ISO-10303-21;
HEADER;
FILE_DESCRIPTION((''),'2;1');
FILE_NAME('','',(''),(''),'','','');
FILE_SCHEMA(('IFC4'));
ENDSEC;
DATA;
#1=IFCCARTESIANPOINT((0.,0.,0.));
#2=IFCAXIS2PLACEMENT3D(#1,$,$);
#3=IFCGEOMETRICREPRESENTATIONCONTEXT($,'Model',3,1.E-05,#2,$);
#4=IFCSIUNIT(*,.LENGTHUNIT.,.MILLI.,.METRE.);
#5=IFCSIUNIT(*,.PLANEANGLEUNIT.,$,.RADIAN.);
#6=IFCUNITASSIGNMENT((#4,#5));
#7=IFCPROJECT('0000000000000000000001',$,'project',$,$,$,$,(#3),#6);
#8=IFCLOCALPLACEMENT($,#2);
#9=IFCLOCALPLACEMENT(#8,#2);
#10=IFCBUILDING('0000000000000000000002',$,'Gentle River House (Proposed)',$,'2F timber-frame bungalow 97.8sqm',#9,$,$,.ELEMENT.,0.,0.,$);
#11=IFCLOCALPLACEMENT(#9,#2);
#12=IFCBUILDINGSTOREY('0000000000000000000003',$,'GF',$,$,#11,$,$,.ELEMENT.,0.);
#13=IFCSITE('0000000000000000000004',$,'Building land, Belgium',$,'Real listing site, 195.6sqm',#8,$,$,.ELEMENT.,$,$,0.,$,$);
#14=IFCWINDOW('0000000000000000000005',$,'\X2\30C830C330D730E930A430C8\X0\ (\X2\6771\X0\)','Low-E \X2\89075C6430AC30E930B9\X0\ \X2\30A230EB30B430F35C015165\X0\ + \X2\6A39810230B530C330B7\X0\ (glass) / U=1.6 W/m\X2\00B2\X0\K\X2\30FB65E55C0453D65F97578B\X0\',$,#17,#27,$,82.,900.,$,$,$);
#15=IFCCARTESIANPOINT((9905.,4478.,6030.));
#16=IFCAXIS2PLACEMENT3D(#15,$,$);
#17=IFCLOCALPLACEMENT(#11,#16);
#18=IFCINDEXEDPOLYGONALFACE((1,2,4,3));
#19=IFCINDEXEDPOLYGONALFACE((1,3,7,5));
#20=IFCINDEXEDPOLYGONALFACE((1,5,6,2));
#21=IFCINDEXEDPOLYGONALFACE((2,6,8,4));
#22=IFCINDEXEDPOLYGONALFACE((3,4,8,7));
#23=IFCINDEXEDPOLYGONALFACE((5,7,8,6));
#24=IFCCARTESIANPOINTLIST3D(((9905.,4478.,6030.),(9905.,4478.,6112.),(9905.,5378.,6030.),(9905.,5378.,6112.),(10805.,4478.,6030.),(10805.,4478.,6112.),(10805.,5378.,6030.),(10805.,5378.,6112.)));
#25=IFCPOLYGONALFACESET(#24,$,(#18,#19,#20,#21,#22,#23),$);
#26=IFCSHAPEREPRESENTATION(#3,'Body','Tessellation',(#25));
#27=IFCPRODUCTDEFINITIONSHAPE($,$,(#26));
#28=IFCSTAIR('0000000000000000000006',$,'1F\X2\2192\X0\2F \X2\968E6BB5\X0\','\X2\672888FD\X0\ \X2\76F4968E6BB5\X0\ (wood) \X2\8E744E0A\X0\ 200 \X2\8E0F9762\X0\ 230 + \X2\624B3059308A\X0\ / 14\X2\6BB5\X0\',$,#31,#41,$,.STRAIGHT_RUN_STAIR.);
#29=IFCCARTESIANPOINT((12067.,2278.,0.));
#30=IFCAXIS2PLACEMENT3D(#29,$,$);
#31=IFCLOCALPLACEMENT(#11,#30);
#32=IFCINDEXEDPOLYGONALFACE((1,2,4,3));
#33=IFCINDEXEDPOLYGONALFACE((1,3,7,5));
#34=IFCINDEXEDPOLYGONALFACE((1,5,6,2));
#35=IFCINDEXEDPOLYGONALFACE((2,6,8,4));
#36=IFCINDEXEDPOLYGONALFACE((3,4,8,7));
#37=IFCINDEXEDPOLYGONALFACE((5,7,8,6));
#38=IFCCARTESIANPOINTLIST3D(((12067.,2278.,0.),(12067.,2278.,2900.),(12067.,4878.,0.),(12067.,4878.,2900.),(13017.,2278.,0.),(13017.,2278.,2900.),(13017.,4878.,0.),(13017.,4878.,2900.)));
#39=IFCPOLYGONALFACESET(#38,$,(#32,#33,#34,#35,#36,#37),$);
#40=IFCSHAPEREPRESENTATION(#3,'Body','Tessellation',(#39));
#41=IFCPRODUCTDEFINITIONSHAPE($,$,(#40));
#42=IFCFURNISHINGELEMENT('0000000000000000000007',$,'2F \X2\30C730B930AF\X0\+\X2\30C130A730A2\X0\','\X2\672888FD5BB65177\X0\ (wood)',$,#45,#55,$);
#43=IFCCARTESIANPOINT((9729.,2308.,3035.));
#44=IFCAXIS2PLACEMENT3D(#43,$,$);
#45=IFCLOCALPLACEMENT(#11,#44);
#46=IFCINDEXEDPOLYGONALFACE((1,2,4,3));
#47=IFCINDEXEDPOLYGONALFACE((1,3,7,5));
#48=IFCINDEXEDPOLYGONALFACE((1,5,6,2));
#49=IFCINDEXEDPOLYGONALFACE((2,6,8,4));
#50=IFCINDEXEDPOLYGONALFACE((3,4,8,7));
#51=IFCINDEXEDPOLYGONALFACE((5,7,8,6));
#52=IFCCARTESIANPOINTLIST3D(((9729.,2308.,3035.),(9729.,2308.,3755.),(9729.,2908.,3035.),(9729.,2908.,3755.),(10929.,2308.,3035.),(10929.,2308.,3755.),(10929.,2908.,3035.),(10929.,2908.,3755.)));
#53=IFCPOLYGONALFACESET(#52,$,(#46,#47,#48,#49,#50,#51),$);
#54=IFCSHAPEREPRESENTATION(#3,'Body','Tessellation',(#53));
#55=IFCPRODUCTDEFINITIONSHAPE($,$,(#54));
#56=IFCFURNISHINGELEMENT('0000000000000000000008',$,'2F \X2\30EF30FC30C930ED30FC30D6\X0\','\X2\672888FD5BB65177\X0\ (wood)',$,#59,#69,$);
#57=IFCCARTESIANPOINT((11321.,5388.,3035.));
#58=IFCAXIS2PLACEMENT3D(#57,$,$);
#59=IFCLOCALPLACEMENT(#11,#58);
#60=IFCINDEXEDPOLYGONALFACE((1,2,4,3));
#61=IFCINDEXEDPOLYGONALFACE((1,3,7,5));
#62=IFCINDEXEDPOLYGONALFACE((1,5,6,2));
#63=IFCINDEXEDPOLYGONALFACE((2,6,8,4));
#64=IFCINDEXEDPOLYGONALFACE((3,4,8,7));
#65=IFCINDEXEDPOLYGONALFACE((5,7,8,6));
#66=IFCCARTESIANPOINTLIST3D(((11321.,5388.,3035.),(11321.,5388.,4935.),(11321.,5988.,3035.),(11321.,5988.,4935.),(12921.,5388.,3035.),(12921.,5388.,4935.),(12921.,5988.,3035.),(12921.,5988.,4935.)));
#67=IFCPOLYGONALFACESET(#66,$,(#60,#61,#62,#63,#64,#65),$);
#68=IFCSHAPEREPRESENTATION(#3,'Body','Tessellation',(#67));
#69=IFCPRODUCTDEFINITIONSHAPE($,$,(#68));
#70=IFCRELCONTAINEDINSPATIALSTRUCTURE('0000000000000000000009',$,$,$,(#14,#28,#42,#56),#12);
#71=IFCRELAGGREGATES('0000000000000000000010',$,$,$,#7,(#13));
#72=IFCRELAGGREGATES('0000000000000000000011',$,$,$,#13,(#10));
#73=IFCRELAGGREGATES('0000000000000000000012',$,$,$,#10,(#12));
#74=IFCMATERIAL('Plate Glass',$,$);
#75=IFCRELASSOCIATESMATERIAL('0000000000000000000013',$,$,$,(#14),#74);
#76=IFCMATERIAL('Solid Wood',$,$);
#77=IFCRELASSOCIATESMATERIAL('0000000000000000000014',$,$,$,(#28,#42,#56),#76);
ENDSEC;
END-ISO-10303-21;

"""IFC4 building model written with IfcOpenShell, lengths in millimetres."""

from ifc_helpers import new_model, si_unit, frame, frame_2d, origin, place, context, project, spatial, rectangle, extrude, material, element, save


model = new_model("IFC4")

# Units and contexts
model_context = context("Model", 3, precision=1e-05, world=origin())
ifc_project = project(units=[si_unit("LENGTHUNIT", "METRE", prefix="MILLI"), si_unit("PLANEANGLEUNIT", "RADIAN")], contexts=[model_context])

# Site, building, storey
site_placement = place(None, origin())
site = spatial("IfcSite", under=ifc_project, at=site_placement, Name="Building land, Belgium", ObjectType="Real listing site, 195.6sqm", CompositionType="ELEMENT", RefElevation=0.0)
building_placement = place(site_placement, origin())
building = spatial("IfcBuilding", under=site, at=building_placement, Name="Gentle River House (Proposed)", ObjectType="2F timber-frame bungalow 97.8sqm", CompositionType="ELEMENT", ElevationOfRefHeight=0.0, ElevationOfTerrain=0.0)
storey_placement = place(building_placement, origin())
storey = spatial("IfcBuildingStorey", under=building, at=storey_placement, Name="GF", CompositionType="ELEMENT", Elevation=0.0)

# Shared definitions
ifc_material_1 = material(Name="Solid Wood")

# Shared definitions
ifc_material_2 = material(Name="Plate Glass")

# Window
window_1_placement = place(storey_placement, frame((9905.0, 4478.0, 6030.0)))
element("IfcWindow", 1, at=window_1_placement, inside=storey, material=ifc_material_2, Name="トップライト (東)", Description="Low-E 複層ガラス アルゴン封入 + 樹脂サッシ (glass) / U=1.6 W/m²K・日射取得型", OverallHeight=82.0, OverallWidth=900.0, context=model_context, shape_type="SweptSolid", body=[
    extrude(rectangle(XDim=900.0, YDim=900.0, at=frame_2d((450.0, 450.0))), frame((9905.0, 4478.0, 6030.0)), (0.0, 0.0, 1.0), 82.0),
])

# Stair
stair_placement = place(storey_placement, frame((12067.0, 2278.0, 0.0)))
element("IfcStair", 2, at=stair_placement, inside=storey, material=ifc_material_1, Name="1F→2F 階段", Description="木製 直階段 (wood) 蹴上 200 踏面 230 + 手すり / 14段", PredefinedType="STRAIGHT_RUN_STAIR", context=model_context, shape_type="SweptSolid", body=[
    extrude(rectangle(XDim=950.0, YDim=2600.0, at=frame_2d((475.0, 1300.0))), frame((12067.0, 2278.0, 0.0)), (0.0, 0.0, 1.0), 2900.0),
])

# Furnishing elements
furnishing_1_placement = place(storey_placement, frame((9729.0, 2308.0, 3035.0)))
element("IfcFurnishingElement", 3, at=furnishing_1_placement, inside=storey, material=ifc_material_1, Name="2F デスク+チェア", Description="木製家具 (wood)", context=model_context, shape_type="SweptSolid", body=[
    extrude(rectangle(XDim=1200.0, YDim=600.0, at=frame_2d((600.0, 300.0))), frame((9729.0, 2308.0, 3035.0)), (0.0, 0.0, 1.0), 720.0),
])
furnishing_2_placement = place(storey_placement, frame((11321.0, 5388.0, 3035.0)))
element("IfcFurnishingElement", 4, at=furnishing_2_placement, inside=storey, material=ifc_material_1, Name="2F ワードローブ", Description="木製家具 (wood)", context=model_context, shape_type="SweptSolid", body=[
    extrude(rectangle(XDim=1600.0, YDim=600.0, at=frame_2d((800.0, 300.0))), frame((11321.0, 5388.0, 3035.0)), (0.0, 0.0, 1.0), 1900.0),
])

save(model, "model.ifc")
